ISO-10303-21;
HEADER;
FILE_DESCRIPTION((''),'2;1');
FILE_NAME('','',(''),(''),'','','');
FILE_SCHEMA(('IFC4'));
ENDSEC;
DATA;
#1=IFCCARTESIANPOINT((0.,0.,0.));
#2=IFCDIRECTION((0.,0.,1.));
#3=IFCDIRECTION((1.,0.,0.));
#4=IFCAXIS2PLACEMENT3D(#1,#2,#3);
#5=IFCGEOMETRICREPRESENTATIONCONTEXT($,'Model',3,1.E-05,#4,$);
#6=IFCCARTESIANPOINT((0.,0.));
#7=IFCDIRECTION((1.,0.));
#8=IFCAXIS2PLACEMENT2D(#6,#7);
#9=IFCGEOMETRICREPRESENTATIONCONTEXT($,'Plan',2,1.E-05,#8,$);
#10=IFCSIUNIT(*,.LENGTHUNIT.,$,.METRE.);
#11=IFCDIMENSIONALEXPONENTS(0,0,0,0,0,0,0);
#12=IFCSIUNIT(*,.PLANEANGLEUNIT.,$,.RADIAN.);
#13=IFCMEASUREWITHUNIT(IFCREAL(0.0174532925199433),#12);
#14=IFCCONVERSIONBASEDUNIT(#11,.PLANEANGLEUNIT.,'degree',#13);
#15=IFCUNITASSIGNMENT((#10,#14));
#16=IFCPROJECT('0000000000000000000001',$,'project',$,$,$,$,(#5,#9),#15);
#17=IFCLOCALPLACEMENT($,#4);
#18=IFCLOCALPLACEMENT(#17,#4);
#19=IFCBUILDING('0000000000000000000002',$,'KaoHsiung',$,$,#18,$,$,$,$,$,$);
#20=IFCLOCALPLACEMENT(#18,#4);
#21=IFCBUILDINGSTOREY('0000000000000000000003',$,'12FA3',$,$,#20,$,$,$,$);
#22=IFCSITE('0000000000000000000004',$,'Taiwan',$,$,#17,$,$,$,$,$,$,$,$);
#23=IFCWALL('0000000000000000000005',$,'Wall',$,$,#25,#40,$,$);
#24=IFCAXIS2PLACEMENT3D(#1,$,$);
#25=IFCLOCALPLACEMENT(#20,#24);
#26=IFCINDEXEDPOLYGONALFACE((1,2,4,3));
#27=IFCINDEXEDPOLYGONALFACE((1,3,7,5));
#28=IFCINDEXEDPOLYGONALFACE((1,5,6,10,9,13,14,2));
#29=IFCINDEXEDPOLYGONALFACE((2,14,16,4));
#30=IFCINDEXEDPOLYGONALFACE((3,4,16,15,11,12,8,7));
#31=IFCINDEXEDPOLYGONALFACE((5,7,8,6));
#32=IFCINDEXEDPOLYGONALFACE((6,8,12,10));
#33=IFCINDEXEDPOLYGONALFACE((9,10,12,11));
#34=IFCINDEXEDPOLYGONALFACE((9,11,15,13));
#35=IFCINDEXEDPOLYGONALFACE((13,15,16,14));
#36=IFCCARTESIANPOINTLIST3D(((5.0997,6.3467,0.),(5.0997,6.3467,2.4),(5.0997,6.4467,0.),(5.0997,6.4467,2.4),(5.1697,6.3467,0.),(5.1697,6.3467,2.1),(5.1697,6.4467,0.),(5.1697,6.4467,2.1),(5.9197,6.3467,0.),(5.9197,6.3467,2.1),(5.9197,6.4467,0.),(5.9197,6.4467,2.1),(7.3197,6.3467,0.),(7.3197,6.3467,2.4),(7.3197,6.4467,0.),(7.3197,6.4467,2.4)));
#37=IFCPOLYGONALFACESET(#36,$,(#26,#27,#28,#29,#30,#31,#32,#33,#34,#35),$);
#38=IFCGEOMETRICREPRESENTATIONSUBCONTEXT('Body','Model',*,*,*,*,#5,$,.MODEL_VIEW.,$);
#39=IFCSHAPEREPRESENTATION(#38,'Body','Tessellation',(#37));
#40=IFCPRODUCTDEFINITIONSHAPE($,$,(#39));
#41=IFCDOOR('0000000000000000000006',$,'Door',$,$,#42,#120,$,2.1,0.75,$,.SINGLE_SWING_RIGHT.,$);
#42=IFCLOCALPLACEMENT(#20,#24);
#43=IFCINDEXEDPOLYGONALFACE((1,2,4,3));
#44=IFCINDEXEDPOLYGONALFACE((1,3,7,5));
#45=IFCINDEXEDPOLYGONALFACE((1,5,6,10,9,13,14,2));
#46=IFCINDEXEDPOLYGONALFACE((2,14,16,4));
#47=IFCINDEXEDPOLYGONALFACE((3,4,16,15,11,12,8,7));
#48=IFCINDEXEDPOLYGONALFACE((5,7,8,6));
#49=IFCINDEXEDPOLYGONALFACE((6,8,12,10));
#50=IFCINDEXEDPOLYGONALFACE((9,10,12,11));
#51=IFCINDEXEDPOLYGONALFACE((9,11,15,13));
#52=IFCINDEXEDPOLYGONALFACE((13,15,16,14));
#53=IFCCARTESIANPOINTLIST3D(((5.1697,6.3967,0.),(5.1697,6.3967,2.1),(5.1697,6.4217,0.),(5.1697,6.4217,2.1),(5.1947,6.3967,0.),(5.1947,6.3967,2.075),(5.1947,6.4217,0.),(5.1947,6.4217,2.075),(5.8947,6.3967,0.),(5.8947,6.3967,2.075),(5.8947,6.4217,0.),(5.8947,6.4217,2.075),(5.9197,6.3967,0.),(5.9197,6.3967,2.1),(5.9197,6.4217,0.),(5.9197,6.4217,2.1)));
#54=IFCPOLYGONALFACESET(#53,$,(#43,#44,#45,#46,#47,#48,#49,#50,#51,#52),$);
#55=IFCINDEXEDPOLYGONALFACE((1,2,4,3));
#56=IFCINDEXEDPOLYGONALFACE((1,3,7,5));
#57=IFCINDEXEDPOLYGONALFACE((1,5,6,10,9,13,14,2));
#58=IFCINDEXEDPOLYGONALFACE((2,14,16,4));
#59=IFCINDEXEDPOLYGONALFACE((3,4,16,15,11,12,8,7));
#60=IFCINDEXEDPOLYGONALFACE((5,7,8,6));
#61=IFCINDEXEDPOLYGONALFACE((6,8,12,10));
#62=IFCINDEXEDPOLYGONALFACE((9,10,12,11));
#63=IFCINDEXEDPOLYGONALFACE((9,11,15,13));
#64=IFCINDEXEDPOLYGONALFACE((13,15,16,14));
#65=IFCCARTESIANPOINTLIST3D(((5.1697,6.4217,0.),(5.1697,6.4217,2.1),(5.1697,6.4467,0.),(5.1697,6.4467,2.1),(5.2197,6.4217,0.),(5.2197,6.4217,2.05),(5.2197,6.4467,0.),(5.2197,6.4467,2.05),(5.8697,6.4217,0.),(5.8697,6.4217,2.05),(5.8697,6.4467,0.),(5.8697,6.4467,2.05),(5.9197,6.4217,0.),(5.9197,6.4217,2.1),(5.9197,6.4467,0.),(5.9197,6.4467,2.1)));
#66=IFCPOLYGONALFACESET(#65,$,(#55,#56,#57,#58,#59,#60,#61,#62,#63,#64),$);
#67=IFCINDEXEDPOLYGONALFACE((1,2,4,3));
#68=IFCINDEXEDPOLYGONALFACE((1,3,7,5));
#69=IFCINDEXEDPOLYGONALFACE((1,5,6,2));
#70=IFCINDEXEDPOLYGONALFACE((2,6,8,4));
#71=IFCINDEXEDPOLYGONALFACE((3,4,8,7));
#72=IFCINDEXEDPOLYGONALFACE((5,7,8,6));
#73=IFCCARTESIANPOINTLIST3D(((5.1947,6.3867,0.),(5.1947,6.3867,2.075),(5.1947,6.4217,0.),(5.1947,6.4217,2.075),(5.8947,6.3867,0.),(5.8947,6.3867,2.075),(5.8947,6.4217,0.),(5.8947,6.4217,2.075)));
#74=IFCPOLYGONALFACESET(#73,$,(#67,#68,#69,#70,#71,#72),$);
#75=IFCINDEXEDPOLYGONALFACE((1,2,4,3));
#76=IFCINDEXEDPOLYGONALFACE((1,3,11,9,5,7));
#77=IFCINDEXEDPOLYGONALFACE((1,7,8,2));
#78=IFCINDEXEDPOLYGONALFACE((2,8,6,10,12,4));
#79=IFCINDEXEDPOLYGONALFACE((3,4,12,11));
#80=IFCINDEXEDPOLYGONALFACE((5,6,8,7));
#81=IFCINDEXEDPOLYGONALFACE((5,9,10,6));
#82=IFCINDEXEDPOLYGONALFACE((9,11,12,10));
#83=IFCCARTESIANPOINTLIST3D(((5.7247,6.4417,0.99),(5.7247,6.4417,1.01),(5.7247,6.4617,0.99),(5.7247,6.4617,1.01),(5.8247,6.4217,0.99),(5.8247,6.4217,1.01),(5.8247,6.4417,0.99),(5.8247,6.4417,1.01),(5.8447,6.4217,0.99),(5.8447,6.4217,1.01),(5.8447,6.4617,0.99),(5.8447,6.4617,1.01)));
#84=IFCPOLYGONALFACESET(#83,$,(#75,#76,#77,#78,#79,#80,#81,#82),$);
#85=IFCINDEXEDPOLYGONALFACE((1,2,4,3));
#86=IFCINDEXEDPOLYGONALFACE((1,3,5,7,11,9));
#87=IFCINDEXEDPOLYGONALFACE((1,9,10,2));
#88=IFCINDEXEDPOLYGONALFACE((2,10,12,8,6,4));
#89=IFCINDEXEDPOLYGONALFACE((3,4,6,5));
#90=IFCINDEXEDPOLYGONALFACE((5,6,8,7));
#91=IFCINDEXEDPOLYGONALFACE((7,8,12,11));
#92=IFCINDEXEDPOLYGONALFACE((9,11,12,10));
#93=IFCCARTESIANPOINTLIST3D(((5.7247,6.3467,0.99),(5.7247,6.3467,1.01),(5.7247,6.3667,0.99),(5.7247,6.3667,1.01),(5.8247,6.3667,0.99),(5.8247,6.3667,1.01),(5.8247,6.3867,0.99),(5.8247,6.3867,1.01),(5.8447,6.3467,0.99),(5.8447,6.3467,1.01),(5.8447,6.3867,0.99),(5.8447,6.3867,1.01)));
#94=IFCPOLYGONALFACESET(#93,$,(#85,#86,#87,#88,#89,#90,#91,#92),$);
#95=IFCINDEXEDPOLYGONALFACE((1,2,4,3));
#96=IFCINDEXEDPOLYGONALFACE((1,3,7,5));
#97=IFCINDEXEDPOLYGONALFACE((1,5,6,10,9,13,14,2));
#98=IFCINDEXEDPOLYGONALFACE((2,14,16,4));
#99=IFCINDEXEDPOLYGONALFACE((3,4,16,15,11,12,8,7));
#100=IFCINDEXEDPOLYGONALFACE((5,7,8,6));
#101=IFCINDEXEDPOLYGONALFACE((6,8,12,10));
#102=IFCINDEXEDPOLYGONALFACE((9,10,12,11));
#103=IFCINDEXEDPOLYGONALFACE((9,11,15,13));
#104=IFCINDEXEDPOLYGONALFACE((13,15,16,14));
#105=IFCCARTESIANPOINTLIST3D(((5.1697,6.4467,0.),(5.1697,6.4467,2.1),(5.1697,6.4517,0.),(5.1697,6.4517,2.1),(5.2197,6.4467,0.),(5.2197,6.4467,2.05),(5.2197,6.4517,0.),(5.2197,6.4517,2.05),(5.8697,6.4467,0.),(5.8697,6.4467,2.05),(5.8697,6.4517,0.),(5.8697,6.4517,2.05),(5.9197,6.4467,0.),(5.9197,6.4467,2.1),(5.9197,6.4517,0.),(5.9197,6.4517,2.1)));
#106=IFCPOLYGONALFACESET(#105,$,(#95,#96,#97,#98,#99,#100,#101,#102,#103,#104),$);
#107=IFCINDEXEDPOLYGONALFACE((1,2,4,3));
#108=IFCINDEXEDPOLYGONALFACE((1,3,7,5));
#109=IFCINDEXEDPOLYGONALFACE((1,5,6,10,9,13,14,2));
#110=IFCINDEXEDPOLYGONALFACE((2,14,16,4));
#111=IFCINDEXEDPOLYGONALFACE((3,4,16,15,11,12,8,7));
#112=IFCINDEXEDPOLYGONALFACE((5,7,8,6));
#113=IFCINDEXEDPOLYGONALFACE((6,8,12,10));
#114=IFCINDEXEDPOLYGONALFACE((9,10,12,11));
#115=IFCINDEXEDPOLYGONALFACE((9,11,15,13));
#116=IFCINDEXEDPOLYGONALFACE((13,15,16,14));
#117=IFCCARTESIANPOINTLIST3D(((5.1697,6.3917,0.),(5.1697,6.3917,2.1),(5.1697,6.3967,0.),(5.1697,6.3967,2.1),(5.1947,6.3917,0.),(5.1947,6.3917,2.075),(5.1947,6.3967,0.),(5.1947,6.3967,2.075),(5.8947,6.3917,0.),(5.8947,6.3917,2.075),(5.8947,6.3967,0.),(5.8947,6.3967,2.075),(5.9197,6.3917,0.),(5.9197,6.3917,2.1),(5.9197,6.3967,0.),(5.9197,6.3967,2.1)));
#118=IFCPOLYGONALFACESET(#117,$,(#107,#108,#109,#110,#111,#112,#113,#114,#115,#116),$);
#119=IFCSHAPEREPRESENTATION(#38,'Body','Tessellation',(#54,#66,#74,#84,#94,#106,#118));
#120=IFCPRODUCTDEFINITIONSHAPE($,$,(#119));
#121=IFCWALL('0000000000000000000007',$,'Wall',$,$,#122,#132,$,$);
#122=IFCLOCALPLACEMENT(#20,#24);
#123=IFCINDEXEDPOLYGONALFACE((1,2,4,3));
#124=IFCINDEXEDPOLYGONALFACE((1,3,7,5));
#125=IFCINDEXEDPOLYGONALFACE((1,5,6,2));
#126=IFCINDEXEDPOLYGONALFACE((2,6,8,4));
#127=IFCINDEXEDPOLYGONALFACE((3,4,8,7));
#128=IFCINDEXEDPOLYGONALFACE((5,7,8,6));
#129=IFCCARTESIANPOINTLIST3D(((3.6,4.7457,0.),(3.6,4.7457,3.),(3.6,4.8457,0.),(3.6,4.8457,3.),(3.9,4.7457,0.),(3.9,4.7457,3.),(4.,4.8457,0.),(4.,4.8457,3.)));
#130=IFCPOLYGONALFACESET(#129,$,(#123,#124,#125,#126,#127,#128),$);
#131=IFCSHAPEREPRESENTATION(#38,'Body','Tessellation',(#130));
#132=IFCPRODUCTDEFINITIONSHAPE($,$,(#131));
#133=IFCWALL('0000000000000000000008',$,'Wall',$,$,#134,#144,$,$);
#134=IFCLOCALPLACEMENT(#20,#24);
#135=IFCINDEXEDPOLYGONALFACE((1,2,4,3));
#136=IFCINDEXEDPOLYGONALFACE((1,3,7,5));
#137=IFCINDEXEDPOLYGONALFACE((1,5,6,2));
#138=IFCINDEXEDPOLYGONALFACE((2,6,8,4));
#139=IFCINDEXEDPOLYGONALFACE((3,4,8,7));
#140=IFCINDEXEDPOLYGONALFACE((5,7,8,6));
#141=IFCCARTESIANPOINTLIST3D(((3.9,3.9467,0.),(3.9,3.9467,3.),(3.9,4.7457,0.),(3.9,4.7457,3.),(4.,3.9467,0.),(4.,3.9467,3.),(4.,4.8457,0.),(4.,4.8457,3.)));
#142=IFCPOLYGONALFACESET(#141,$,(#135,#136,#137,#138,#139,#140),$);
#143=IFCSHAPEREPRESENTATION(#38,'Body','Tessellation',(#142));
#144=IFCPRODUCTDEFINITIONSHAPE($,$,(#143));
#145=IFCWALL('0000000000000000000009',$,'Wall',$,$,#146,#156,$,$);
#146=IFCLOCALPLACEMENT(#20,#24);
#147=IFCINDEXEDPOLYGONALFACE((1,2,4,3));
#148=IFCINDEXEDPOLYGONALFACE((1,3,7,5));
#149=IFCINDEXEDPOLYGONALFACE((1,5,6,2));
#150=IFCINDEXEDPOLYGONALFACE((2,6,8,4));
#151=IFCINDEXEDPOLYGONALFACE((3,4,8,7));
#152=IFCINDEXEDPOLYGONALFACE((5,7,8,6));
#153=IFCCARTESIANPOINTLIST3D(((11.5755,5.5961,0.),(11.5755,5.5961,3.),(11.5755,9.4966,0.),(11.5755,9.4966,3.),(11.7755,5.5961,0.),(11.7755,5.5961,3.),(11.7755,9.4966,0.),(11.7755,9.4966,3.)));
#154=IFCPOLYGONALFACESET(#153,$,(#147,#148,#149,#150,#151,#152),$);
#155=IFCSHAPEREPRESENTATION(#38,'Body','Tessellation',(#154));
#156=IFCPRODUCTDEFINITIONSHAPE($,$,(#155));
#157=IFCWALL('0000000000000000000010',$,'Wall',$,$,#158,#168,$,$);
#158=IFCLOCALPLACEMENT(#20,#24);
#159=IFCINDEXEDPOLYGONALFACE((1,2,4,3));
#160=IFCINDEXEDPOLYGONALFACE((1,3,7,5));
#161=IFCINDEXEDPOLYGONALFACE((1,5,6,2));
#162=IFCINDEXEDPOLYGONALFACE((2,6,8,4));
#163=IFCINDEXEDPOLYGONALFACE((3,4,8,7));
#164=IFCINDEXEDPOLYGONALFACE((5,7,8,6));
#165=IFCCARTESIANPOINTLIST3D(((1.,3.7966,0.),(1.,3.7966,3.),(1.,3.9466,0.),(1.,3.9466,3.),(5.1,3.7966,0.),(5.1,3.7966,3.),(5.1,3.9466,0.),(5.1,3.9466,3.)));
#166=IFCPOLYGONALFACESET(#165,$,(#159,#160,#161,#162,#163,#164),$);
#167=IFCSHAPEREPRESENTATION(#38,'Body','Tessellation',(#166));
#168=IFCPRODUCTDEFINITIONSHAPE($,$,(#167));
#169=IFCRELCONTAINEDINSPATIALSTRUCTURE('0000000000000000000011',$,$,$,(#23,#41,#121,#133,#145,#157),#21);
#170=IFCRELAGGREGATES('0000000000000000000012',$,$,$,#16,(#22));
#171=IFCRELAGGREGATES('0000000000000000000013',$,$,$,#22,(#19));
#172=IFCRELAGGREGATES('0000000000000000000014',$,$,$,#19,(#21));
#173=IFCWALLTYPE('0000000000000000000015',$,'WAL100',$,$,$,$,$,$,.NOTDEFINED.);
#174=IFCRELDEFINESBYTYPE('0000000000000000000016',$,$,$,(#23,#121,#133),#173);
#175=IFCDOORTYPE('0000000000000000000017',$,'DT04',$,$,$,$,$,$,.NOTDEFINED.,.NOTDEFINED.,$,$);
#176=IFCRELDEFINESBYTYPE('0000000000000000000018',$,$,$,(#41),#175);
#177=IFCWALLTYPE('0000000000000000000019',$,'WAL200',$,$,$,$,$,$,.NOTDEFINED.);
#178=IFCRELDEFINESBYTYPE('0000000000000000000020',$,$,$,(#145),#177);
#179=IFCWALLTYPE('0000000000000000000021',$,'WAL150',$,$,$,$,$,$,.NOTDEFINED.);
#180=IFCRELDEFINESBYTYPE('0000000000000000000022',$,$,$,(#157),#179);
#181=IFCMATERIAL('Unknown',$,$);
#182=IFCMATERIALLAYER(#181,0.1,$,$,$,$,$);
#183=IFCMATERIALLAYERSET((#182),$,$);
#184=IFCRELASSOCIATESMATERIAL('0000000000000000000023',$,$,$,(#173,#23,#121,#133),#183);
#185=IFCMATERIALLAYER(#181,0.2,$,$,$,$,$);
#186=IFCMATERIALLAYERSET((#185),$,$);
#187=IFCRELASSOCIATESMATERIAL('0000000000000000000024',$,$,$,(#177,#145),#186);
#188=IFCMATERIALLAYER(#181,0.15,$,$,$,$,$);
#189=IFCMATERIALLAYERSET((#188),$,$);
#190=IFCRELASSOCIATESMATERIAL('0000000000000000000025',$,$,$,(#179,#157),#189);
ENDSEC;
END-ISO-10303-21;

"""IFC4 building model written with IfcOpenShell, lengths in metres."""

from ifc_helpers import new_model, entity, si_unit, converted_unit, frame, origin_with_axes, origin_2d_with_axis, place, context, subcontext, project, spatial, line, indexed_curve, outline, extrude, shape, source, transform, mapped, material, layer, layer_set, layer_usage, type_object, type_shapes, element, fill, save


model = new_model("IFC4")

# Units and contexts
model_context = context("Model", 3, precision=1e-05, world=origin_with_axes())
plan_context = context("Plan", 2, precision=1e-05, world=origin_2d_with_axis())
body_context_1 = subcontext(model_context, "Body", "Model", "MODEL_VIEW")
body_context_2 = subcontext(plan_context, "Body", "Plan", "PLAN_VIEW")
ifc_project = project(units=[si_unit("LENGTHUNIT", "METRE"), converted_unit("PLANEANGLEUNIT", "degree", entity("IfcReal", 0.0174532925199433), si_unit("PLANEANGLEUNIT", "RADIAN"), dimensions=[0, 0, 0, 0, 0, 0, 0])], contexts=[model_context, plan_context])

# Site, building, storey
site_placement = place(None, origin_with_axes())
site = spatial("IfcSite", under=ifc_project, at=site_placement, Name="Taiwan")
building_placement = place(site_placement, origin_with_axes())
building = spatial("IfcBuilding", under=site, at=building_placement, Name="KaoHsiung")
storey_placement = place(building_placement, origin_with_axes())
storey = spatial("IfcBuildingStorey", under=building, at=storey_placement, Name="12FA3")

# Shared definitions
ifc_material = material(Name="Unknown")

# Shared definitions
ifc_layer_1 = layer(ifc_material, 0.1)
ifc_layer_set_1 = layer_set([ifc_layer_1])
wall_type_1 = type_object("IfcWallType", Name="WAL100", PredefinedType="NOTDEFINED", material=ifc_layer_set_1)

# Wall, opening, door
ifc_layer_usage_1 = layer_usage(ifc_layer_set_1, "AXIS2", "POSITIVE", 0.0)
wall_1_placement = place(storey_placement, frame((7.3197, 6.4467, 0.0), z_axis=(0.0, 0.0, 1.0), x_axis=(-1.0, 0.0, 0.0)))
wall_1 = element("IfcWall", 1, at=wall_1_placement, inside=storey, type_object=wall_type_1, material=ifc_layer_usage_1, Name="Wall", context=body_context_1, shape_type="SweptSolid", body=[
    extrude(outline(indexed_curve([(0.0, 0.0), (0.0, 0.1), (2.22, 0.1), (2.22, 0.0)], segments=[line(1, 2, 3, 4, 1)])), origin_with_axes(), (0.0, 0.0, 1.0), 2.4),
])
shared_shape_1 = source(origin_with_axes(), body_context_1, "Body", "SweptSolid", [
    extrude(outline(indexed_curve([(0.0, 0.0), (0.75, 0.0), (0.75, 2.1), (0.0, 2.1)], segments=[line(1, 2, 3, 4, 1)])), frame((0.0, -0.6, 0.0), z_axis=(0.0, -1.0, 0.0), x_axis=(1.0, 0.0, 0.0)), (0.0, 0.0, -1.0), 1.2),
])
opening_1_placement = place(wall_1_placement, frame((1.4, 0.0, 0.0), z_axis=(0.0, 0.0, 1.0), x_axis=(1.0, 0.0, 0.0)))
opening_1 = element("IfcOpeningElement", 2, at=opening_1_placement, cuts=wall_1, PredefinedType="OPENING", context=body_context_1, shape_type="MappedRepresentation", body=[
    mapped(shared_shape_1, transform((0.0, 0.0, 0.0), x_axis=(1.0, 0.0, 0.0), y_axis=(0.0, 1.0, 0.0), z_axis=(0.0, 0.0, 1.0), scale=1.0)),
])
door_type_1 = type_object("IfcDoorType", Name="DT04", OperationType="NOTDEFINED", PredefinedType="NOTDEFINED")
shared_shape_2 = source(origin_with_axes(), body_context_1, "Body", "SweptSolid", [
    extrude(outline(indexed_curve([(0.0, 0.0), (0.0, 2.1), (0.75, 2.1), (0.75, 0.0), (0.725, 0.0), (0.725, 2.075), (0.025, 2.075), (0.025, 0.0)], segments=[line(1, 2, 3, 4, 5, 6, 7, 8, 1)])), frame((0.0, 0.025, 0.0), z_axis=(0.0, -1.0, 0.0), x_axis=(1.0, 0.0, 0.0)), (0.0, 0.0, -1.0), 0.025),
    extrude(outline(indexed_curve([(0.0, 0.0), (0.0, 2.1), (0.75, 2.1), (0.75, 0.0), (0.7, 0.0), (0.7, 2.05), (0.05, 2.05), (0.05, 0.0)], segments=[line(1, 2, 3, 4, 5, 6, 7, 8, 1)])), frame((0.0, 0.0, 0.0), z_axis=(0.0, -1.0, 0.0), x_axis=(1.0, 0.0, 0.0)), (0.0, 0.0, -1.0), 0.025),
    extrude(outline(indexed_curve([(0.0, 0.0), (0.7, 0.0), (0.7, 0.035), (0.0, 0.035)], segments=[line(1, 2, 3, 4, 1)])), frame((0.025, 0.025, 0.0), z_axis=(0.0, 0.0, 1.0), x_axis=(1.0, 0.0, 0.0)), (0.0, 0.0, 1.0), 2.075),
    extrude(outline(indexed_curve([(0.0, 0.0), (0.0, -0.04), (0.12, -0.04), (0.12, -0.02), (0.02, -0.02), (0.02, 0.0)], segments=[line(1, 2, 3, 4, 5, 6, 1)])), frame((0.075, 0.025, 0.99), z_axis=(0.0, 0.0, 1.0), x_axis=(1.0, 0.0, 0.0)), (0.0, 0.0, 1.0), 0.02),
    extrude(outline(indexed_curve([(0.0, 0.0), (0.0, 0.04), (0.12, 0.04), (0.12, 0.02), (0.02, 0.02), (0.02, 0.0)], segments=[line(1, 2, 3, 4, 5, 6, 1)])), frame((0.075, 0.06, 0.99), z_axis=(0.0, 0.0, 1.0), x_axis=(1.0, 0.0, 0.0)), (0.0, 0.0, 1.0), 0.02),
    extrude(outline(indexed_curve([(0.0, 0.0), (0.0, 2.1), (0.75, 2.1), (0.75, 0.0), (0.7, 0.0), (0.7, 2.05), (0.05, 2.05), (0.05, 0.0)], segments=[line(1, 2, 3, 4, 5, 6, 7, 8, 1)])), frame((0.0, -0.005, 0.0), z_axis=(0.0, -1.0, 0.0), x_axis=(1.0, 0.0, 0.0)), (0.0, 0.0, -1.0), 0.005),
    extrude(outline(indexed_curve([(0.0, 0.0), (0.0, 2.1), (0.75, 2.1), (0.75, 0.0), (0.725, 0.0), (0.725, 2.075), (0.025, 2.075), (0.025, 0.0)], segments=[line(1, 2, 3, 4, 5, 6, 7, 8, 1)])), frame((0.0, 0.05, 0.0), z_axis=(0.0, -1.0, 0.0), x_axis=(1.0, 0.0, 0.0)), (0.0, 0.0, -1.0), 0.005),
])
shared_shape_3 = source(origin_with_axes(), body_context_2, "Body", "Curve2D", [
    entity("IfcIndexedPolyCurve", entity("IfcCartesianPointList2D", [[0.0, 0.0], [0.0, 0.05], [0.025, 0.05], [0.025, 0.025], [0.05, 0.025], [0.05, 0.0]]), [entity("IfcLineIndex", [1, 2, 3, 4, 5, 6, 1])]),
    entity("IfcIndexedPolyCurve", entity("IfcCartesianPointList2D", [[0.75, 0.0], [0.75, 0.05], [0.725, 0.05], [0.725, 0.025], [0.7, 0.025], [0.7, 0.0]]), [entity("IfcLineIndex", [1, 2, 3, 4, 5, 6, 1])]),
    entity("IfcTrimmedCurve", entity("IfcEllipse", entity("IfcAxis2Placement2D", entity("IfcCartesianPoint", [0.69, 0.05]), entity("IfcDirection", [1.0, 0.0])), 0.665, 0.7), [entity("IfcCartesianPoint", [0.69, 0.75])], [entity("IfcCartesianPoint", [0.025, 0.05])], True, "CARTESIAN"),
    entity("IfcIndexedPolyCurve", entity("IfcCartesianPointList2D", [[0.725, 0.05], [0.69, 0.05], [0.69, 0.75], [0.725, 0.75]]), [entity("IfcLineIndex", [1, 2, 3, 4, 1])]),
])
type_shapes(door_type_1, [shared_shape_2, shared_shape_3])
door_1_placement = place(opening_1_placement, frame((0.0, 0.0, 0.0), z_axis=(0.0, 0.0, 1.0), x_axis=(1.0, 0.0, 0.0)))
door_1 = element("IfcDoor", 3, at=door_1_placement, inside=storey, type_object=door_type_1, Name="Door", OperationType="SINGLE_SWING_RIGHT", OverallHeight=2.1, OverallWidth=0.75, shapes=[
    shape(body_context_1, "Body", "MappedRepresentation", [mapped(shared_shape_2, transform((0.0, 0.0, 0.0), x_axis=(1.0, 0.0, 0.0), y_axis=(0.0, 1.0, 0.0), z_axis=(0.0, 0.0, 1.0), scale=1.0))]),
    shape(body_context_2, "Body", "MappedRepresentation", [mapped(shared_shape_3, transform((0.0, 0.0, 0.0), x_axis=(1.0, 0.0, 0.0), y_axis=(0.0, 1.0, 0.0), z_axis=(0.0, 0.0, 1.0), scale=1.0))]),
])
fill(opening_1, door_1)

# Walls
ifc_layer_usage_2 = layer_usage(ifc_layer_set_1, "AXIS2", "POSITIVE", 0.0)
wall_2_placement = place(storey_placement, frame((3.6, 4.7457, 0.0), z_axis=(0.0, 0.0, 1.0), x_axis=(1.0, 0.0, 0.0)))
element("IfcWall", 4, at=wall_2_placement, inside=storey, type_object=wall_type_1, material=ifc_layer_usage_2, Name="Wall", context=body_context_1, shape_type="SweptSolid", body=[
    extrude(outline(indexed_curve([(0.0, 0.0), (0.0, 0.1), (0.4, 0.1), (0.3, 0.0)], segments=[line(1, 2, 3, 4, 1)])), origin_with_axes(), (0.0, 0.0, 1.0), 3.0),
])
ifc_layer_usage_3 = layer_usage(ifc_layer_set_1, "AXIS2", "POSITIVE", 0.0)
wall_3_placement = place(storey_placement, frame((3.9, 4.7457, 0.0), z_axis=(0.0, 0.0, 1.0), x_axis=(0.0, -1.0, 0.0)))
element("IfcWall", 5, at=wall_3_placement, inside=storey, type_object=wall_type_1, material=ifc_layer_usage_3, Name="Wall", context=body_context_1, shape_type="SweptSolid", body=[
    extrude(outline(indexed_curve([(0.0, 0.0), (-0.1, 0.1), (0.799, 0.1), (0.799, 0.0)], segments=[line(1, 2, 3, 4, 1)])), origin_with_axes(), (0.0, 0.0, 1.0), 3.0),
])
ifc_layer_2 = layer(ifc_material, 0.2)
ifc_layer_set_2 = layer_set([ifc_layer_2])
ifc_layer_usage_4 = layer_usage(ifc_layer_set_2, "AXIS2", "POSITIVE", 0.0)
wall_type_2 = type_object("IfcWallType", Name="WAL200", PredefinedType="NOTDEFINED", material=ifc_layer_set_2)
wall_4_placement = place(storey_placement, frame((11.7755, 5.5961, 0.0), z_axis=(0.0, 0.0, 1.0), x_axis=(0.0, 1.0, 0.0)))
element("IfcWall", 6, at=wall_4_placement, inside=storey, type_object=wall_type_2, material=ifc_layer_usage_4, Name="Wall", context=body_context_1, shape_type="SweptSolid", body=[
    extrude(outline(indexed_curve([(0.0, 0.0), (0.0, 0.2), (3.9005, 0.2), (3.9005, 0.0)], segments=[line(1, 2, 3, 4, 1)])), origin_with_axes(), (0.0, 0.0, 1.0), 3.0),
])
ifc_layer_3 = layer(ifc_material, 0.15)
ifc_layer_set_3 = layer_set([ifc_layer_3])
ifc_layer_usage_5 = layer_usage(ifc_layer_set_3, "AXIS2", "POSITIVE", 0.0)
wall_type_3 = type_object("IfcWallType", Name="WAL150", PredefinedType="NOTDEFINED", material=ifc_layer_set_3)
wall_5_placement = place(storey_placement, frame((1.0, 3.7966, 0.0), z_axis=(0.0, 0.0, 1.0), x_axis=(1.0, 0.0, 0.0)))
element("IfcWall", 7, at=wall_5_placement, inside=storey, type_object=wall_type_3, material=ifc_layer_usage_5, Name="Wall", context=body_context_1, shape_type="SweptSolid", body=[
    extrude(outline(indexed_curve([(0.0, 0.0), (0.0, 0.15), (4.1, 0.15), (4.1, 0.0)], segments=[line(1, 2, 3, 4, 1)])), origin_with_axes(), (0.0, 0.0, 1.0), 3.0),
])

save(model, "model.ifc")
